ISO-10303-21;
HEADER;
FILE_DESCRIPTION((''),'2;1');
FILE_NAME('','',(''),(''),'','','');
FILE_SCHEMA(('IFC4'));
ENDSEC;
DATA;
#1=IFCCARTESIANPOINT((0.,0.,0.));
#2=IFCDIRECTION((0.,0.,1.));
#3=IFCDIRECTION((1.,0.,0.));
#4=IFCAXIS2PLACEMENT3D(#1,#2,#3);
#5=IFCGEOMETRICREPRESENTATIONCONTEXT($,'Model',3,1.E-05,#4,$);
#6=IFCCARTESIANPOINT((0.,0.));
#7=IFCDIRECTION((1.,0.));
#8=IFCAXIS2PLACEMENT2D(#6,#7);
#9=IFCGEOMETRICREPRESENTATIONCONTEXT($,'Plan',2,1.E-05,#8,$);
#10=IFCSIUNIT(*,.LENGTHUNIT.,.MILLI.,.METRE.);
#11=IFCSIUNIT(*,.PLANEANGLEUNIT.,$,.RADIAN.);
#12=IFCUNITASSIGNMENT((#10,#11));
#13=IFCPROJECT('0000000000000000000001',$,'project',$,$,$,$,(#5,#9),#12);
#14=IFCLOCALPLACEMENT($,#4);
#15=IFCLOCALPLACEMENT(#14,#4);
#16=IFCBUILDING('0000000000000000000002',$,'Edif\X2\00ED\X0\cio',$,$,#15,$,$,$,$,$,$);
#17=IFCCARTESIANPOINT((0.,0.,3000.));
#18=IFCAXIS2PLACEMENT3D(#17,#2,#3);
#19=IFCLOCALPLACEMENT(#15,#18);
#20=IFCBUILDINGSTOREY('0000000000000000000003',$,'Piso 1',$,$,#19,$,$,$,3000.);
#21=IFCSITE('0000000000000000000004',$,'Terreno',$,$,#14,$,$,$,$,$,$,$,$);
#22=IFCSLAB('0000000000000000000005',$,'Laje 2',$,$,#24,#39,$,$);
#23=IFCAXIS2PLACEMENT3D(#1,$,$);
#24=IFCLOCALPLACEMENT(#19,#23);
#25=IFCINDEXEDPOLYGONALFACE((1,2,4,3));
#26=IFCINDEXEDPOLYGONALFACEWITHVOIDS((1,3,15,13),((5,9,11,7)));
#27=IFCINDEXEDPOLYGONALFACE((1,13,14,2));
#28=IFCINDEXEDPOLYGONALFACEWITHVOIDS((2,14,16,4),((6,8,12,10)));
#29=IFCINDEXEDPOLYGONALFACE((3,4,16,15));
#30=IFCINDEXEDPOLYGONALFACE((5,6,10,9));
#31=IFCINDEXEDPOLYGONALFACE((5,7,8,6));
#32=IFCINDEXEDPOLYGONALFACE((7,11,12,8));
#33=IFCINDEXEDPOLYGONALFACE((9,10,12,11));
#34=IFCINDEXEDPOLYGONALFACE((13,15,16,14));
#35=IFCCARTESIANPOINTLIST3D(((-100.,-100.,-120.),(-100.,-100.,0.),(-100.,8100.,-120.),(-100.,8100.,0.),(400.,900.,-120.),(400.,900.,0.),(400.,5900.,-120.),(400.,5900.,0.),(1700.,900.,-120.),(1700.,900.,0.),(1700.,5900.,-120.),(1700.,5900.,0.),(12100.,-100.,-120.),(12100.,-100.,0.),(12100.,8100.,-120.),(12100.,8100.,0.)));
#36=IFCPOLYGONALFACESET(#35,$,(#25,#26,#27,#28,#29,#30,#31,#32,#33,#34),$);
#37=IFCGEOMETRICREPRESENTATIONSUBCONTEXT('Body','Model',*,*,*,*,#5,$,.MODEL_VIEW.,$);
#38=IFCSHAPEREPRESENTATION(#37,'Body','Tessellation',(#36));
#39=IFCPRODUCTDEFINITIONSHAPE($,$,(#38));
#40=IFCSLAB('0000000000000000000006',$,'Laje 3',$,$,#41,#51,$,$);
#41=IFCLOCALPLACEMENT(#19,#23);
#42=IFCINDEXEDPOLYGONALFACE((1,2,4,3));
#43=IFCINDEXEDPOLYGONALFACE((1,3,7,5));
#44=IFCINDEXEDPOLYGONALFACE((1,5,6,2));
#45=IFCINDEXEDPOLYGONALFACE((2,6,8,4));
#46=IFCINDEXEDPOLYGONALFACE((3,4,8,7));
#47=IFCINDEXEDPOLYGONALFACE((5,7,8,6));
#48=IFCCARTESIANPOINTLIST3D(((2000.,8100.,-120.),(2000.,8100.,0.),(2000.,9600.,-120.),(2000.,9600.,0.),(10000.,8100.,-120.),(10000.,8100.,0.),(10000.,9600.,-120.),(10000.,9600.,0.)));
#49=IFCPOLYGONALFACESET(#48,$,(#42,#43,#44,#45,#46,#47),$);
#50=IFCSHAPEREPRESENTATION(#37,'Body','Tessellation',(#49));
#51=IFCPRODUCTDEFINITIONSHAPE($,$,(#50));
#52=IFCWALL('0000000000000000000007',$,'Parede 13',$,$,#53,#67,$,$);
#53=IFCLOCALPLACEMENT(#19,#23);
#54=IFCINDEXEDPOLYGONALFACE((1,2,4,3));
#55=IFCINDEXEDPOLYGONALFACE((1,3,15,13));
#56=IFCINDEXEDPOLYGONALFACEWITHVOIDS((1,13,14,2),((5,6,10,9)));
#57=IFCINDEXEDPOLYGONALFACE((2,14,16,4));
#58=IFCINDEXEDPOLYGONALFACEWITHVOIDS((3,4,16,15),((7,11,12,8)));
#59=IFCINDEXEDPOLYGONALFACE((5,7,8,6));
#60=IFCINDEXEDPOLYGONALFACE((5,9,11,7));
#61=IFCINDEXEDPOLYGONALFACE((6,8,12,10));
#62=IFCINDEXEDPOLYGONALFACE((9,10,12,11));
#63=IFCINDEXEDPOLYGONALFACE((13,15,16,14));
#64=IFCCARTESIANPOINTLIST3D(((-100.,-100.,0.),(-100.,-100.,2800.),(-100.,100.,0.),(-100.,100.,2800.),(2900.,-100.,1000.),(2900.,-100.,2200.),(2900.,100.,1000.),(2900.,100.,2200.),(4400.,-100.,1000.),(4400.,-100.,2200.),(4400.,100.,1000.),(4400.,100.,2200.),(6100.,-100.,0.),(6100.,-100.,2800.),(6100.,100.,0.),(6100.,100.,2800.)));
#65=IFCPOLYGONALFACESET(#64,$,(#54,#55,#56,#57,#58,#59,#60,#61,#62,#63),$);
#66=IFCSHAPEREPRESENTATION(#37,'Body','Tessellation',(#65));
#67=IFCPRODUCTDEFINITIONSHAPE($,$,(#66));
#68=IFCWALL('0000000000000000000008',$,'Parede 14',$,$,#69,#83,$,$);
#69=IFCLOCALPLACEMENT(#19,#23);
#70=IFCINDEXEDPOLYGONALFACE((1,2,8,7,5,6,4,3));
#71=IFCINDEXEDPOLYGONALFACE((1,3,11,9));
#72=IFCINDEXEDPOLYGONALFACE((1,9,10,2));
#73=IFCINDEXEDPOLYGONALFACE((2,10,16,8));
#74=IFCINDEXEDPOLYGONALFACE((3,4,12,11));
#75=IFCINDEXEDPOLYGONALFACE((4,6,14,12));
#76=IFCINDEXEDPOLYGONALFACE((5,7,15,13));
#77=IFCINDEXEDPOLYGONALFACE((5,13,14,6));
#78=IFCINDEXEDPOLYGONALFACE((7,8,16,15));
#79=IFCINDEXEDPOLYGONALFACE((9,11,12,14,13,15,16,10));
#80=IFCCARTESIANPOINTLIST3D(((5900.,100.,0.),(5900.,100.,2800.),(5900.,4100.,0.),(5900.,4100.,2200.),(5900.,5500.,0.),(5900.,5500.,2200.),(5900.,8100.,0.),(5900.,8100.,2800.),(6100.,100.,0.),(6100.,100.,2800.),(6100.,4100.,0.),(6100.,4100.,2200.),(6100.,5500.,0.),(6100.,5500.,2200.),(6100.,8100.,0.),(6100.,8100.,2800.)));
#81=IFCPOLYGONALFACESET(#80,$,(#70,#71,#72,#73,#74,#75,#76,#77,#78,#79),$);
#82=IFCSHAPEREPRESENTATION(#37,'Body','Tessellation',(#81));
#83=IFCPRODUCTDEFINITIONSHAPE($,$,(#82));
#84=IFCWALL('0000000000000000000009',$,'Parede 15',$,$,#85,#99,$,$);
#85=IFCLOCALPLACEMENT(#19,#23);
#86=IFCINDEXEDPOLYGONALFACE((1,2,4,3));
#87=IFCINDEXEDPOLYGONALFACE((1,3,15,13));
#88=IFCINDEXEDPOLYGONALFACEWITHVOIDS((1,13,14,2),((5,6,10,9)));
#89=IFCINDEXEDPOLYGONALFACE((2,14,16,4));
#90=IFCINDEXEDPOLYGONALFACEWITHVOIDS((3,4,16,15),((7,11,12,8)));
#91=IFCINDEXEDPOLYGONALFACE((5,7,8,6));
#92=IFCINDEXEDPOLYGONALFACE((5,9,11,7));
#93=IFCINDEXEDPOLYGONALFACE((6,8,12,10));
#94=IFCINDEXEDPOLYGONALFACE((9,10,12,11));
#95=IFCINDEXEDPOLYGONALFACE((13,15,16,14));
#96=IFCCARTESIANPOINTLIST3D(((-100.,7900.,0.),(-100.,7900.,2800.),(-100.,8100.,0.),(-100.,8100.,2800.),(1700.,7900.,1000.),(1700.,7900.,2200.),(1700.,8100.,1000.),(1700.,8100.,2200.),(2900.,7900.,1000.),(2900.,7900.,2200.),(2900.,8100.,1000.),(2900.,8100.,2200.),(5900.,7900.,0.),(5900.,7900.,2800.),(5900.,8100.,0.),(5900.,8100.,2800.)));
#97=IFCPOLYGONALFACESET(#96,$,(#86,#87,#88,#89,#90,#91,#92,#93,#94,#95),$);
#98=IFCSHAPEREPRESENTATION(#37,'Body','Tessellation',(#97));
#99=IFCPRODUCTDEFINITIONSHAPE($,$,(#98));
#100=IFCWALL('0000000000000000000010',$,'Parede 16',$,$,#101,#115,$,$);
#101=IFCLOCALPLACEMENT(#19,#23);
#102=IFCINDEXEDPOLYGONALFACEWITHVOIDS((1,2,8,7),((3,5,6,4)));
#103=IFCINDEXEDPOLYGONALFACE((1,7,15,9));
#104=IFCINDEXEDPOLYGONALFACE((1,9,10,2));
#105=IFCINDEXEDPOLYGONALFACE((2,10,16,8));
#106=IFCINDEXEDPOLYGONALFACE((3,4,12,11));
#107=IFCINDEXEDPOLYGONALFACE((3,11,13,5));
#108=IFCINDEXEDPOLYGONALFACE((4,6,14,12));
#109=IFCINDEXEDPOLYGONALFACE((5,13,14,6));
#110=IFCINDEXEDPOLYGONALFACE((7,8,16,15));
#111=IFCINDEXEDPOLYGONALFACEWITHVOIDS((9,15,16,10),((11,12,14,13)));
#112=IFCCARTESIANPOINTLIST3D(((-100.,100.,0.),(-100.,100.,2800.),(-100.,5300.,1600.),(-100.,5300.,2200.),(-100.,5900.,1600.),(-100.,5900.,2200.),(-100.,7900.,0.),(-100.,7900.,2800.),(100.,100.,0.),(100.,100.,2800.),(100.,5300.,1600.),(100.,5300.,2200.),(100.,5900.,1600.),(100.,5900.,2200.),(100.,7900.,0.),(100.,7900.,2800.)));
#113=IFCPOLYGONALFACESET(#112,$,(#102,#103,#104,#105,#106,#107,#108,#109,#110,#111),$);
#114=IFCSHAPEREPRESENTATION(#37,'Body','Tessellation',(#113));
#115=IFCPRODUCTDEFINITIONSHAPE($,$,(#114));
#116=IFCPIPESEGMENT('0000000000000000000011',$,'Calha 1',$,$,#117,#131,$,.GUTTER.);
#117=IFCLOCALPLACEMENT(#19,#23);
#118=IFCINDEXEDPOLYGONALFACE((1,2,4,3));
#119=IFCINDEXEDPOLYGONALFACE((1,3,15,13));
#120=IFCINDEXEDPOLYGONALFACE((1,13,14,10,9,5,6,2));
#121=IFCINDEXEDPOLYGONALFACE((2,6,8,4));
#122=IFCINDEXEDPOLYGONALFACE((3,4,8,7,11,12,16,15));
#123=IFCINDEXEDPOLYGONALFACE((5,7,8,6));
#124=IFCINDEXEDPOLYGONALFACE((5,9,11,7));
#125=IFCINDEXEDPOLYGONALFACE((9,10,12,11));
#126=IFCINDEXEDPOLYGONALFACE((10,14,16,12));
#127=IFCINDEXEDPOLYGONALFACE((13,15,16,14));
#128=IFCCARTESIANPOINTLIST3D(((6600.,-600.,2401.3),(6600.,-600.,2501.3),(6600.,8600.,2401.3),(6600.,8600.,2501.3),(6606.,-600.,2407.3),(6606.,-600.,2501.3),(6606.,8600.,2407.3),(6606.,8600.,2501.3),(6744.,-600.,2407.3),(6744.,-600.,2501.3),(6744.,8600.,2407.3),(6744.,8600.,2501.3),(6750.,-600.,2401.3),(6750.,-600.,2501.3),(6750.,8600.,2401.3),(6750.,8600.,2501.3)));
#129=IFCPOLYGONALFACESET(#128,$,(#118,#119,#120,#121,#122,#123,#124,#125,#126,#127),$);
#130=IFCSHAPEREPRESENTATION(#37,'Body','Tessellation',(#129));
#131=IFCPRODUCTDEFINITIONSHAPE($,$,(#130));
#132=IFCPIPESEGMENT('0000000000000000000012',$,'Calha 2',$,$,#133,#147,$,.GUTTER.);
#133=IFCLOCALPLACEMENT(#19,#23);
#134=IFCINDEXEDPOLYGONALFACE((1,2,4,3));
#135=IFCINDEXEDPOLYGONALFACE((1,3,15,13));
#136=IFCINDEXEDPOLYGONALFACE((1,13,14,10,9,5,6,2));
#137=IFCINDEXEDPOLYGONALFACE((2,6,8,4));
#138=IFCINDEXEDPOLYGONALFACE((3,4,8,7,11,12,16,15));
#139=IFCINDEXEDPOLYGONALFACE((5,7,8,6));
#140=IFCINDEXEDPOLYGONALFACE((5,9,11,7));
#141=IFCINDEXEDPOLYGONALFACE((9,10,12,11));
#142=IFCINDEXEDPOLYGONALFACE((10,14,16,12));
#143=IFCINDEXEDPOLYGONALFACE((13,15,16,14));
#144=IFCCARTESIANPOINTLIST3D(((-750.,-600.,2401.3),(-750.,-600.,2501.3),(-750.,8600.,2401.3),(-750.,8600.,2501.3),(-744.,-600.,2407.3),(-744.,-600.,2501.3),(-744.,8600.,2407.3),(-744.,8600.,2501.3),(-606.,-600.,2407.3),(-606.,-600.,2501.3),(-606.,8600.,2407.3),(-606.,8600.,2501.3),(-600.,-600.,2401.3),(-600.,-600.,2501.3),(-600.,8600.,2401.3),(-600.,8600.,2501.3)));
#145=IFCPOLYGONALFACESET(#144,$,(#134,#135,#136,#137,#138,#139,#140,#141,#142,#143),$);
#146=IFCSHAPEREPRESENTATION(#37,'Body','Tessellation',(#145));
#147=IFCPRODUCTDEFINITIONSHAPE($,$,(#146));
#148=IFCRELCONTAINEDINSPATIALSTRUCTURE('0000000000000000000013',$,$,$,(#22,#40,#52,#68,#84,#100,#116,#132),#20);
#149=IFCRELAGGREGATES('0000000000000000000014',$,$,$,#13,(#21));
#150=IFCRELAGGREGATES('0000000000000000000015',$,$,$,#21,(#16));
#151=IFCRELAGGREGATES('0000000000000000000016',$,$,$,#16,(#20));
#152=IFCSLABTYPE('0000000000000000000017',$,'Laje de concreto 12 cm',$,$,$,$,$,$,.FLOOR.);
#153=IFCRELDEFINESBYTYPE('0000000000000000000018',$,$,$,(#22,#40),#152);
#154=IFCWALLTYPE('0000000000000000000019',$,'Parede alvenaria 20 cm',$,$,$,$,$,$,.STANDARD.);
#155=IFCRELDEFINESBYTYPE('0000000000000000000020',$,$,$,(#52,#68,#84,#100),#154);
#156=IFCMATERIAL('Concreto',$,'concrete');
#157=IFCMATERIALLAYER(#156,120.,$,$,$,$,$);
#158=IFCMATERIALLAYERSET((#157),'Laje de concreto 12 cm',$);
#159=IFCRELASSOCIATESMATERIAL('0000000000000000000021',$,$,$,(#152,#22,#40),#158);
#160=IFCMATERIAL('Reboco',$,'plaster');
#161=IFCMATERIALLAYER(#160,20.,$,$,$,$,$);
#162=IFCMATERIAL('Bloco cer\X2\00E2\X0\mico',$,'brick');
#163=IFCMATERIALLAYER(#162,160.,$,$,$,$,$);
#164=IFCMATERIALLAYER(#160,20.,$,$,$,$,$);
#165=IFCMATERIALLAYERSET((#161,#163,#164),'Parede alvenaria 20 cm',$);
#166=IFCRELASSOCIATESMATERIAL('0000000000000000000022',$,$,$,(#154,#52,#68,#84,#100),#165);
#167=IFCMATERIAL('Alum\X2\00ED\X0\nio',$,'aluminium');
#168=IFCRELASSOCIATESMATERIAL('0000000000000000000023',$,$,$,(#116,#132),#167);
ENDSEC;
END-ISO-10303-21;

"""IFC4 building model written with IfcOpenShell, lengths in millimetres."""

from ifc_helpers import new_model, si_unit, frame, origin_with_axes, origin_2d_with_axis, place, context, subcontext, project, spatial, indexed_curve, outline, extrude, material, layer, layer_set, layer_usage, type_object, element, save


model = new_model("IFC4")

# Units and contexts
model_context = context("Model", 3, precision=1e-05, world=origin_with_axes())
plan_context = context("Plan", 2, precision=1e-05, world=origin_2d_with_axis())
body_context = subcontext(model_context, "Body", "Model", "MODEL_VIEW")
ifc_project = project(units=[si_unit("LENGTHUNIT", "METRE", prefix="MILLI"), si_unit("PLANEANGLEUNIT", "RADIAN")], contexts=[model_context, plan_context])

# Site, building, storey
site_placement = place(None, origin_with_axes())
site = spatial("IfcSite", under=ifc_project, at=site_placement, Name="Terreno")
building_placement = place(site_placement, origin_with_axes())
building = spatial("IfcBuilding", under=site, at=building_placement, Name="Edifício")
storey_placement = place(building_placement, frame((0.0, 0.0, 3000.0), z_axis=(0.0, 0.0, 1.0), x_axis=(1.0, 0.0, 0.0)))
storey = spatial("IfcBuildingStorey", under=building, at=storey_placement, Name="Piso 1", Elevation=3000.0)

# Slabs
ifc_material_1 = material(Name="Concreto", Category="concrete")
ifc_layer_1 = layer(ifc_material_1, 120.0)
ifc_layer_set_1 = layer_set([ifc_layer_1], Name="Laje de concreto 12 cm")
ifc_layer_usage_1 = layer_usage(ifc_layer_set_1, "AXIS3", "POSITIVE", 0.0)
slab_type = type_object("IfcSlabType", Name="Laje de concreto 12 cm", PredefinedType="FLOOR", material=ifc_layer_set_1)
slab_1_placement = place(storey_placement, frame((-100.0, -100.0, -120.0), z_axis=(0.0, 0.0, 1.0), x_axis=(1.0, 0.0, 0.0)))
element("IfcSlab", 1, at=slab_1_placement, inside=storey, type_object=slab_type, material=ifc_layer_usage_1, Name="Laje 2", context=body_context, shape_type="SweptSolid", body=[
    extrude(outline(indexed_curve([(0.0, 0.0), (12200.0, 0.0), (12200.0, 8200.0), (0.0, 8200.0), (0.0, 0.0)], self_intersect=False), holes=[indexed_curve([(500.0, 1000.0), (1800.0, 1000.0), (1800.0, 6000.0), (500.0, 6000.0), (500.0, 1000.0)], self_intersect=False)]), origin_with_axes(), (0.0, 0.0, 1.0), 120.0),
])
ifc_layer_usage_2 = layer_usage(ifc_layer_set_1, "AXIS3", "POSITIVE", 0.0)
slab_2_placement = place(storey_placement, frame((2000.0, 8100.0, -120.0), z_axis=(0.0, 0.0, 1.0), x_axis=(1.0, 0.0, 0.0)))
element("IfcSlab", 2, at=slab_2_placement, inside=storey, type_object=slab_type, material=ifc_layer_usage_2, Name="Laje 3", context=body_context, shape_type="SweptSolid", body=[
    extrude(outline(indexed_curve([(0.0, 0.0), (8000.0, 0.0), (8000.0, 1500.0), (0.0, 1500.0), (0.0, 0.0)], self_intersect=False)), origin_with_axes(), (0.0, 0.0, 1.0), 120.0),
])

# Walls, openings
ifc_material_2 = material(Name="Reboco", Category="plaster")
ifc_layer_2 = layer(ifc_material_2, 20.0)
ifc_material_3 = material(Name="Bloco cerâmico", Category="brick")
ifc_layer_3 = layer(ifc_material_3, 160.0)
ifc_layer_4 = layer(ifc_material_2, 20.0)
ifc_layer_set_2 = layer_set([ifc_layer_2, ifc_layer_3, ifc_layer_4], Name="Parede alvenaria 20 cm")
ifc_layer_usage_3 = layer_usage(ifc_layer_set_2, "AXIS2", "POSITIVE", -100.0)
wall_type = type_object("IfcWallType", Name="Parede alvenaria 20 cm", PredefinedType="STANDARD", material=ifc_layer_set_2)
wall_1_placement = place(storey_placement, frame((-100.0, 0.0, 0.0), z_axis=(0.0, 0.0, 1.0), x_axis=(1.0, 0.0, 0.0)))
wall_1 = element("IfcWall", 3, at=wall_1_placement, inside=storey, type_object=wall_type, material=ifc_layer_usage_3, Name="Parede 13", context=body_context, shape_type="SweptSolid", body=[
    extrude(outline(indexed_curve([(0.0, 0.0), (0.0, 200.0), (6200.0, 200.0), (6200.0, 0.0), (0.0, 0.0)], self_intersect=False)), frame((0.0, -100.0, 0.0), z_axis=(0.0, 0.0, 1.0), x_axis=(1.0, 0.0, 0.0)), (0.0, 0.0, 1.0), 2800.0),
])
opening_1_placement = place(wall_1_placement, frame((3000.0, -110.0, 1000.0), z_axis=(0.0, 0.0, 1.0), x_axis=(1.0, 0.0, 0.0)))
element("IfcOpeningElement", 4, at=opening_1_placement, cuts=wall_1, context=body_context, shape_type="SweptSolid", body=[
    extrude(outline(indexed_curve([(0.0, 0.0), (0.0, 220.0), (1500.0, 220.0), (1500.0, 0.0), (0.0, 0.0)], self_intersect=False)), origin_with_axes(), (0.0, 0.0, 1.0), 1200.0),
])
ifc_layer_usage_4 = layer_usage(ifc_layer_set_2, "AXIS2", "POSITIVE", -100.0)
wall_2_placement = place(storey_placement, frame((6000.0, 100.0, 0.0), z_axis=(0.0, 0.0, 1.0), x_axis=(0.0, 1.0, 0.0)))
wall_2 = element("IfcWall", 5, at=wall_2_placement, inside=storey, type_object=wall_type, material=ifc_layer_usage_4, Name="Parede 14", context=body_context, shape_type="SweptSolid", body=[
    extrude(outline(indexed_curve([(0.0, 0.0), (0.0, 200.0), (8000.0, 200.0), (8000.0, 0.0), (0.0, 0.0)], self_intersect=False)), frame((0.0, -100.0, 0.0), z_axis=(0.0, 0.0, 1.0), x_axis=(1.0, 0.0, 0.0)), (0.0, 0.0, 1.0), 2800.0),
])
opening_2_placement = place(wall_2_placement, frame((4000.0, -110.0, 0.0), z_axis=(0.0, 0.0, 1.0), x_axis=(1.0, 0.0, 0.0)))
element("IfcOpeningElement", 6, at=opening_2_placement, cuts=wall_2, context=body_context, shape_type="SweptSolid", body=[
    extrude(outline(indexed_curve([(0.0, 0.0), (0.0, 220.0), (1400.0, 220.0), (1400.0, 0.0), (0.0, 0.0)], self_intersect=False)), origin_with_axes(), (0.0, 0.0, 1.0), 2200.0),
])
ifc_layer_usage_5 = layer_usage(ifc_layer_set_2, "AXIS2", "POSITIVE", -100.0)
wall_3_placement = place(storey_placement, frame((5900.0, 8000.0, 0.0), z_axis=(0.0, 0.0, 1.0), x_axis=(-1.0, 0.0, 0.0)))
wall_3 = element("IfcWall", 7, at=wall_3_placement, inside=storey, type_object=wall_type, material=ifc_layer_usage_5, Name="Parede 15", context=body_context, shape_type="SweptSolid", body=[
    extrude(outline(indexed_curve([(0.0, 0.0), (0.0, 200.0), (6000.0, 200.0), (6000.0, 0.0), (0.0, 0.0)], self_intersect=False)), frame((0.0, -100.0, 0.0), z_axis=(0.0, 0.0, 1.0), x_axis=(1.0, 0.0, 0.0)), (0.0, 0.0, 1.0), 2800.0),
])
opening_3_placement = place(wall_3_placement, frame((3000.0, -110.0, 1000.0), z_axis=(0.0, 0.0, 1.0), x_axis=(1.0, 0.0, 0.0)))
element("IfcOpeningElement", 8, at=opening_3_placement, cuts=wall_3, context=body_context, shape_type="SweptSolid", body=[
    extrude(outline(indexed_curve([(0.0, 0.0), (0.0, 220.0), (1200.0, 220.0), (1200.0, 0.0), (0.0, 0.0)], self_intersect=False)), origin_with_axes(), (0.0, 0.0, 1.0), 1200.0),
])
ifc_layer_usage_6 = layer_usage(ifc_layer_set_2, "AXIS2", "POSITIVE", -100.0)
wall_4_placement = place(storey_placement, frame((0.0, 7900.0, 0.0), z_axis=(0.0, 0.0, 1.0), x_axis=(0.0, -1.0, 0.0)))
wall_4 = element("IfcWall", 9, at=wall_4_placement, inside=storey, type_object=wall_type, material=ifc_layer_usage_6, Name="Parede 16", context=body_context, shape_type="SweptSolid", body=[
    extrude(outline(indexed_curve([(0.0, 0.0), (0.0, 200.0), (7800.0, 200.0), (7800.0, 0.0), (0.0, 0.0)], self_intersect=False)), frame((0.0, -100.0, 0.0), z_axis=(0.0, 0.0, 1.0), x_axis=(1.0, 0.0, 0.0)), (0.0, 0.0, 1.0), 2800.0),
])
opening_4_placement = place(wall_4_placement, frame((2000.0, -110.0, 1600.0), z_axis=(0.0, 0.0, 1.0), x_axis=(1.0, 0.0, 0.0)))
element("IfcOpeningElement", 10, at=opening_4_placement, cuts=wall_4, context=body_context, shape_type="SweptSolid", body=[
    extrude(outline(indexed_curve([(0.0, 0.0), (0.0, 220.0), (600.0, 220.0), (600.0, 0.0), (0.0, 0.0)], self_intersect=False)), origin_with_axes(), (0.0, 0.0, 1.0), 600.0),
])

# Pipe segments
ifc_material_4 = material(Name="Alumínio", Category="aluminium")
pipe_segment_1_placement = place(storey_placement, frame((6600.0, 8600.0, 2501.3), z_axis=(0.0, 0.0, 1.0), x_axis=(0.0, -1.0, 0.0)))
element("IfcPipeSegment", 11, at=pipe_segment_1_placement, inside=storey, material=ifc_material_4, Name="Calha 1", PredefinedType="GUTTER", context=body_context, shape_type="SweptSolid", body=[
    extrude(outline(indexed_curve([(0.0, -100.0), (150.0, -100.0), (150.0, 0.0), (144.0, 0.0), (144.0, -94.0), (6.0, -94.0), (6.0, 0.0), (0.0, 0.0), (0.0, -100.0)], self_intersect=False)), frame((0.0, 0.0, 0.0), z_axis=(1.0, 0.0, 0.0), x_axis=(0.0, 1.0, 0.0)), (0.0, 0.0, 1.0), 9200.0),
])
pipe_segment_2_placement = place(storey_placement, frame((-600.0, -600.0, 2501.3), z_axis=(0.0, 0.0, 1.0), x_axis=(0.0, 1.0, 0.0)))
element("IfcPipeSegment", 12, at=pipe_segment_2_placement, inside=storey, material=ifc_material_4, Name="Calha 2", PredefinedType="GUTTER", context=body_context, shape_type="SweptSolid", body=[
    extrude(outline(indexed_curve([(0.0, -100.0), (150.0, -100.0), (150.0, 0.0), (144.0, 0.0), (144.0, -94.0), (6.0, -94.0), (6.0, 0.0), (0.0, 0.0), (0.0, -100.0)], self_intersect=False)), frame((0.0, 0.0, 0.0), z_axis=(1.0, 0.0, 0.0), x_axis=(0.0, 1.0, 0.0)), (0.0, 0.0, 1.0), 9200.0),
])

save(model, "model.ifc")
